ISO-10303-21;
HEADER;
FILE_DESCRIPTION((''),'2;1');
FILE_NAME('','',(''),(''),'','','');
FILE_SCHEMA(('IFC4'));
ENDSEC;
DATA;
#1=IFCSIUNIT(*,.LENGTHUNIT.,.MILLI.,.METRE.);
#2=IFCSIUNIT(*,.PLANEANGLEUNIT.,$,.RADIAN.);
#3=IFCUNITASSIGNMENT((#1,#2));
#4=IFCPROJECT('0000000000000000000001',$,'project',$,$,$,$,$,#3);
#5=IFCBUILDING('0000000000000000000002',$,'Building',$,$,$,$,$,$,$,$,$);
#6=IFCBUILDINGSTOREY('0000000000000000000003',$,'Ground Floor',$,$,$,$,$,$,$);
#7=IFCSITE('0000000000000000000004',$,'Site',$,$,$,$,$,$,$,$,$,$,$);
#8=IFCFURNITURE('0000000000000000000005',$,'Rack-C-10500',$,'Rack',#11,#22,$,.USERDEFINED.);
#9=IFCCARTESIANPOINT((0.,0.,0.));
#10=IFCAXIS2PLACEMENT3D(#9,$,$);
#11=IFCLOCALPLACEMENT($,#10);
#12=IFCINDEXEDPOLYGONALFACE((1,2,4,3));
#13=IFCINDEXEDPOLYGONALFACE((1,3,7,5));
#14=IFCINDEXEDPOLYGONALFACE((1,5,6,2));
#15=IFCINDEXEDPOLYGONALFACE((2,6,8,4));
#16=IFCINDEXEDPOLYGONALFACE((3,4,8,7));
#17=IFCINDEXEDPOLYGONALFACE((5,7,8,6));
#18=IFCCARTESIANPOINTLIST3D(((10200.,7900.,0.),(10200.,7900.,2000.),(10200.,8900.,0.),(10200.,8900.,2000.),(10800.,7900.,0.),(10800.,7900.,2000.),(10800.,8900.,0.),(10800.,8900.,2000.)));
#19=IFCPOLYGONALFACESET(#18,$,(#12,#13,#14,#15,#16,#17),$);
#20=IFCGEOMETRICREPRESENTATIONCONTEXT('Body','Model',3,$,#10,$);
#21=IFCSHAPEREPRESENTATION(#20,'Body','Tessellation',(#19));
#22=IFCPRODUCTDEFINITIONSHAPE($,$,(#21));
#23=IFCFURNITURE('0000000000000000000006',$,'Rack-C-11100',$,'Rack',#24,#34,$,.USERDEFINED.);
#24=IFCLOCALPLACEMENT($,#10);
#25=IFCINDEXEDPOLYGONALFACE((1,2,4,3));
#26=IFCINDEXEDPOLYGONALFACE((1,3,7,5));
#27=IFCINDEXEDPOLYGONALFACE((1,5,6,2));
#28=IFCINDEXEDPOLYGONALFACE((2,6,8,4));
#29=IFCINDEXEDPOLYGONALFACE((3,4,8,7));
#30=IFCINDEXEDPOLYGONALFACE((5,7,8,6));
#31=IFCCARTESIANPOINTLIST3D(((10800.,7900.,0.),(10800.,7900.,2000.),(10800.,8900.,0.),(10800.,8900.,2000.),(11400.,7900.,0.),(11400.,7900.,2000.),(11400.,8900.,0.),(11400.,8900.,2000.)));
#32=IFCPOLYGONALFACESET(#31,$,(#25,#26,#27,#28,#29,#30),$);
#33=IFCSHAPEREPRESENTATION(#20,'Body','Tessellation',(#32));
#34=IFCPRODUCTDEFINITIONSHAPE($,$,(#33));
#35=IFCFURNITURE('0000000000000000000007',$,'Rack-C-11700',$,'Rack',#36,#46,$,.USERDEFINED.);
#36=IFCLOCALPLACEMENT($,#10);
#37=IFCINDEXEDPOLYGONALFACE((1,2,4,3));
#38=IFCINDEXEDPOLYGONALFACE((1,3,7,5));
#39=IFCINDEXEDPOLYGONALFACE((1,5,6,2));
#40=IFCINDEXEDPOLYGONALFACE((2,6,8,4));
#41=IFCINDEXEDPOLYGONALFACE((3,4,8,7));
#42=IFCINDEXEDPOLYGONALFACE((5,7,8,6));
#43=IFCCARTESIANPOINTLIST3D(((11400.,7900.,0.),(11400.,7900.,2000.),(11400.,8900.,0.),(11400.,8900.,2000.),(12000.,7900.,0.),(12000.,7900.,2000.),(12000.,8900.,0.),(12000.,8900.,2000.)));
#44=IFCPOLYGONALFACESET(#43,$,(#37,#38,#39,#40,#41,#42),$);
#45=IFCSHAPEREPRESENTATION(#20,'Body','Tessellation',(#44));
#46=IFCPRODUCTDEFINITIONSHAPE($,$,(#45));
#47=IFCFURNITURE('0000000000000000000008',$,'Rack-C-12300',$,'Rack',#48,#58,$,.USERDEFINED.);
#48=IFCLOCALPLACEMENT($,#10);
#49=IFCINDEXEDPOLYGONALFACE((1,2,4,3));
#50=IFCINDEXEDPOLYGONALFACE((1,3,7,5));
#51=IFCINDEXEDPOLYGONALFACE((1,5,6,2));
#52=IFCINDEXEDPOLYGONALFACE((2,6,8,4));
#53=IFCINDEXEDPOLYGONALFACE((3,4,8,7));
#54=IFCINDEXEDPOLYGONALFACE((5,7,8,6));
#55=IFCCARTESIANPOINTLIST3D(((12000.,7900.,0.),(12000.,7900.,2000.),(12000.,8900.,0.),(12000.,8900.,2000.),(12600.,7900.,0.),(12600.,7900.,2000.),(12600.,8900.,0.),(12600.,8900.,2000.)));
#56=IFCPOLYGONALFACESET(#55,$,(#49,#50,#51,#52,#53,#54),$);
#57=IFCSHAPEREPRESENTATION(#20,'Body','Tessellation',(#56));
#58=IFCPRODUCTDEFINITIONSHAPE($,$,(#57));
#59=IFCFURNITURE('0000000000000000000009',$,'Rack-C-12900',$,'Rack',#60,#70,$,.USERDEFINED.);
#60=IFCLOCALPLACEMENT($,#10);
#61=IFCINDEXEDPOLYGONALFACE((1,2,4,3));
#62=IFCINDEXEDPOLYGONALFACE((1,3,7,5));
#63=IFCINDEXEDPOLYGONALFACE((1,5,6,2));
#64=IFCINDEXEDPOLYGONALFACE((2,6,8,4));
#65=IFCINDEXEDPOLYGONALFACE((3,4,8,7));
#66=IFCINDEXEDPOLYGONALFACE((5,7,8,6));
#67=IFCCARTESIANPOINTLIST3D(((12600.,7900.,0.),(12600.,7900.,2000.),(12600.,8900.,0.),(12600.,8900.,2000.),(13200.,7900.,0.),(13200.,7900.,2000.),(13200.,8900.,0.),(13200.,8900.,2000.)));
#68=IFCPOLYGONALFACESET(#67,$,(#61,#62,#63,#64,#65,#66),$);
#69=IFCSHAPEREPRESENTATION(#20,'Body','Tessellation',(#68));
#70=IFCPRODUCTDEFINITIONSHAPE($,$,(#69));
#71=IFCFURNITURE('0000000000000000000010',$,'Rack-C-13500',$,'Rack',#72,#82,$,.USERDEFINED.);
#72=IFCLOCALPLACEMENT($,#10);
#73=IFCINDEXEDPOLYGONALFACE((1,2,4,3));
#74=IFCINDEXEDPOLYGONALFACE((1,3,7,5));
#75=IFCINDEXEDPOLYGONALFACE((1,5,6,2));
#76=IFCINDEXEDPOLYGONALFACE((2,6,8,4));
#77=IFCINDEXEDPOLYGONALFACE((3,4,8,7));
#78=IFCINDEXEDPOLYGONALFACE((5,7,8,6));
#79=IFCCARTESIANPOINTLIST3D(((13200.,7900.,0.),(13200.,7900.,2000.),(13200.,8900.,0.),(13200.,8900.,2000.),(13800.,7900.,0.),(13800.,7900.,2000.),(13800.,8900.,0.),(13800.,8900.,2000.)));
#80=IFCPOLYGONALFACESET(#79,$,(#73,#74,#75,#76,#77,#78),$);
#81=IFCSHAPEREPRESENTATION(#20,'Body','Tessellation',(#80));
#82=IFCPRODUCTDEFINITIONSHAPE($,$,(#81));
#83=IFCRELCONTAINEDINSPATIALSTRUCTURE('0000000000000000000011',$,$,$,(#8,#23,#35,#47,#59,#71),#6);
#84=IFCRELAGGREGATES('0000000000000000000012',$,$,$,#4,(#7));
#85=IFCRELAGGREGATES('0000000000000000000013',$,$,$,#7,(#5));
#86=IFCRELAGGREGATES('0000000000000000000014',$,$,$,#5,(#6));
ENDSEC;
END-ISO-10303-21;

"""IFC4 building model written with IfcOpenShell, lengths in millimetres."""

from ifc_helpers import new_model, si_unit, frame, origin, place, context, project, spatial, rectangle, extrude, element, save


model = new_model("IFC4")

# Units and contexts
model_context = context("Model", 3, world=origin(), identifier="Body")
ifc_project = project(units=[si_unit("LENGTHUNIT", "METRE", prefix="MILLI"), si_unit("PLANEANGLEUNIT", "RADIAN")])

# Site, building, storey
site = spatial("IfcSite", under=ifc_project, Name="Site")
building = spatial("IfcBuilding", under=site, Name="Building")
storey = spatial("IfcBuildingStorey", under=building, Name="Ground Floor")

# Furniture
for number, where, z_axis, x_axis, name in (
    (1, (10500.0, 8400.0, 0.0), (0.0, 0.0, 1.0), (1.0, 0.0, 0.0), "Rack-C-10500"),
    (2, (11100.0, 8400.0, 0.0), (0.0, 0.0, 1.0), (1.0, 0.0, 0.0), "Rack-C-11100"),
    (3, (11700.0, 8400.0, 0.0), (0.0, 0.0, 1.0), (1.0, 0.0, 0.0), "Rack-C-11700"),
    (4, (12300.0, 8400.0, 0.0), (0.0, 0.0, 1.0), (1.0, 0.0, 0.0), "Rack-C-12300"),
    (5, (12900.0, 8400.0, 0.0), (0.0, 0.0, 1.0), (1.0, 0.0, 0.0), "Rack-C-12900"),
    (6, (13500.0, 8400.0, 0.0), (0.0, 0.0, 1.0), (1.0, 0.0, 0.0), "Rack-C-13500"),
):
    element("IfcFurniture", number, at=place(None, frame(where, z_axis=z_axis, x_axis=x_axis)), inside=storey, Name=name, ObjectType="Rack", PredefinedType="USERDEFINED", context=model_context, shape_type="SweptSolid", body=[
        extrude(rectangle(XDim=600.0, YDim=1000.0), origin(), (0.0, 0.0, 1.0), 2000.0),
    ])

save(model, "model.ifc")
